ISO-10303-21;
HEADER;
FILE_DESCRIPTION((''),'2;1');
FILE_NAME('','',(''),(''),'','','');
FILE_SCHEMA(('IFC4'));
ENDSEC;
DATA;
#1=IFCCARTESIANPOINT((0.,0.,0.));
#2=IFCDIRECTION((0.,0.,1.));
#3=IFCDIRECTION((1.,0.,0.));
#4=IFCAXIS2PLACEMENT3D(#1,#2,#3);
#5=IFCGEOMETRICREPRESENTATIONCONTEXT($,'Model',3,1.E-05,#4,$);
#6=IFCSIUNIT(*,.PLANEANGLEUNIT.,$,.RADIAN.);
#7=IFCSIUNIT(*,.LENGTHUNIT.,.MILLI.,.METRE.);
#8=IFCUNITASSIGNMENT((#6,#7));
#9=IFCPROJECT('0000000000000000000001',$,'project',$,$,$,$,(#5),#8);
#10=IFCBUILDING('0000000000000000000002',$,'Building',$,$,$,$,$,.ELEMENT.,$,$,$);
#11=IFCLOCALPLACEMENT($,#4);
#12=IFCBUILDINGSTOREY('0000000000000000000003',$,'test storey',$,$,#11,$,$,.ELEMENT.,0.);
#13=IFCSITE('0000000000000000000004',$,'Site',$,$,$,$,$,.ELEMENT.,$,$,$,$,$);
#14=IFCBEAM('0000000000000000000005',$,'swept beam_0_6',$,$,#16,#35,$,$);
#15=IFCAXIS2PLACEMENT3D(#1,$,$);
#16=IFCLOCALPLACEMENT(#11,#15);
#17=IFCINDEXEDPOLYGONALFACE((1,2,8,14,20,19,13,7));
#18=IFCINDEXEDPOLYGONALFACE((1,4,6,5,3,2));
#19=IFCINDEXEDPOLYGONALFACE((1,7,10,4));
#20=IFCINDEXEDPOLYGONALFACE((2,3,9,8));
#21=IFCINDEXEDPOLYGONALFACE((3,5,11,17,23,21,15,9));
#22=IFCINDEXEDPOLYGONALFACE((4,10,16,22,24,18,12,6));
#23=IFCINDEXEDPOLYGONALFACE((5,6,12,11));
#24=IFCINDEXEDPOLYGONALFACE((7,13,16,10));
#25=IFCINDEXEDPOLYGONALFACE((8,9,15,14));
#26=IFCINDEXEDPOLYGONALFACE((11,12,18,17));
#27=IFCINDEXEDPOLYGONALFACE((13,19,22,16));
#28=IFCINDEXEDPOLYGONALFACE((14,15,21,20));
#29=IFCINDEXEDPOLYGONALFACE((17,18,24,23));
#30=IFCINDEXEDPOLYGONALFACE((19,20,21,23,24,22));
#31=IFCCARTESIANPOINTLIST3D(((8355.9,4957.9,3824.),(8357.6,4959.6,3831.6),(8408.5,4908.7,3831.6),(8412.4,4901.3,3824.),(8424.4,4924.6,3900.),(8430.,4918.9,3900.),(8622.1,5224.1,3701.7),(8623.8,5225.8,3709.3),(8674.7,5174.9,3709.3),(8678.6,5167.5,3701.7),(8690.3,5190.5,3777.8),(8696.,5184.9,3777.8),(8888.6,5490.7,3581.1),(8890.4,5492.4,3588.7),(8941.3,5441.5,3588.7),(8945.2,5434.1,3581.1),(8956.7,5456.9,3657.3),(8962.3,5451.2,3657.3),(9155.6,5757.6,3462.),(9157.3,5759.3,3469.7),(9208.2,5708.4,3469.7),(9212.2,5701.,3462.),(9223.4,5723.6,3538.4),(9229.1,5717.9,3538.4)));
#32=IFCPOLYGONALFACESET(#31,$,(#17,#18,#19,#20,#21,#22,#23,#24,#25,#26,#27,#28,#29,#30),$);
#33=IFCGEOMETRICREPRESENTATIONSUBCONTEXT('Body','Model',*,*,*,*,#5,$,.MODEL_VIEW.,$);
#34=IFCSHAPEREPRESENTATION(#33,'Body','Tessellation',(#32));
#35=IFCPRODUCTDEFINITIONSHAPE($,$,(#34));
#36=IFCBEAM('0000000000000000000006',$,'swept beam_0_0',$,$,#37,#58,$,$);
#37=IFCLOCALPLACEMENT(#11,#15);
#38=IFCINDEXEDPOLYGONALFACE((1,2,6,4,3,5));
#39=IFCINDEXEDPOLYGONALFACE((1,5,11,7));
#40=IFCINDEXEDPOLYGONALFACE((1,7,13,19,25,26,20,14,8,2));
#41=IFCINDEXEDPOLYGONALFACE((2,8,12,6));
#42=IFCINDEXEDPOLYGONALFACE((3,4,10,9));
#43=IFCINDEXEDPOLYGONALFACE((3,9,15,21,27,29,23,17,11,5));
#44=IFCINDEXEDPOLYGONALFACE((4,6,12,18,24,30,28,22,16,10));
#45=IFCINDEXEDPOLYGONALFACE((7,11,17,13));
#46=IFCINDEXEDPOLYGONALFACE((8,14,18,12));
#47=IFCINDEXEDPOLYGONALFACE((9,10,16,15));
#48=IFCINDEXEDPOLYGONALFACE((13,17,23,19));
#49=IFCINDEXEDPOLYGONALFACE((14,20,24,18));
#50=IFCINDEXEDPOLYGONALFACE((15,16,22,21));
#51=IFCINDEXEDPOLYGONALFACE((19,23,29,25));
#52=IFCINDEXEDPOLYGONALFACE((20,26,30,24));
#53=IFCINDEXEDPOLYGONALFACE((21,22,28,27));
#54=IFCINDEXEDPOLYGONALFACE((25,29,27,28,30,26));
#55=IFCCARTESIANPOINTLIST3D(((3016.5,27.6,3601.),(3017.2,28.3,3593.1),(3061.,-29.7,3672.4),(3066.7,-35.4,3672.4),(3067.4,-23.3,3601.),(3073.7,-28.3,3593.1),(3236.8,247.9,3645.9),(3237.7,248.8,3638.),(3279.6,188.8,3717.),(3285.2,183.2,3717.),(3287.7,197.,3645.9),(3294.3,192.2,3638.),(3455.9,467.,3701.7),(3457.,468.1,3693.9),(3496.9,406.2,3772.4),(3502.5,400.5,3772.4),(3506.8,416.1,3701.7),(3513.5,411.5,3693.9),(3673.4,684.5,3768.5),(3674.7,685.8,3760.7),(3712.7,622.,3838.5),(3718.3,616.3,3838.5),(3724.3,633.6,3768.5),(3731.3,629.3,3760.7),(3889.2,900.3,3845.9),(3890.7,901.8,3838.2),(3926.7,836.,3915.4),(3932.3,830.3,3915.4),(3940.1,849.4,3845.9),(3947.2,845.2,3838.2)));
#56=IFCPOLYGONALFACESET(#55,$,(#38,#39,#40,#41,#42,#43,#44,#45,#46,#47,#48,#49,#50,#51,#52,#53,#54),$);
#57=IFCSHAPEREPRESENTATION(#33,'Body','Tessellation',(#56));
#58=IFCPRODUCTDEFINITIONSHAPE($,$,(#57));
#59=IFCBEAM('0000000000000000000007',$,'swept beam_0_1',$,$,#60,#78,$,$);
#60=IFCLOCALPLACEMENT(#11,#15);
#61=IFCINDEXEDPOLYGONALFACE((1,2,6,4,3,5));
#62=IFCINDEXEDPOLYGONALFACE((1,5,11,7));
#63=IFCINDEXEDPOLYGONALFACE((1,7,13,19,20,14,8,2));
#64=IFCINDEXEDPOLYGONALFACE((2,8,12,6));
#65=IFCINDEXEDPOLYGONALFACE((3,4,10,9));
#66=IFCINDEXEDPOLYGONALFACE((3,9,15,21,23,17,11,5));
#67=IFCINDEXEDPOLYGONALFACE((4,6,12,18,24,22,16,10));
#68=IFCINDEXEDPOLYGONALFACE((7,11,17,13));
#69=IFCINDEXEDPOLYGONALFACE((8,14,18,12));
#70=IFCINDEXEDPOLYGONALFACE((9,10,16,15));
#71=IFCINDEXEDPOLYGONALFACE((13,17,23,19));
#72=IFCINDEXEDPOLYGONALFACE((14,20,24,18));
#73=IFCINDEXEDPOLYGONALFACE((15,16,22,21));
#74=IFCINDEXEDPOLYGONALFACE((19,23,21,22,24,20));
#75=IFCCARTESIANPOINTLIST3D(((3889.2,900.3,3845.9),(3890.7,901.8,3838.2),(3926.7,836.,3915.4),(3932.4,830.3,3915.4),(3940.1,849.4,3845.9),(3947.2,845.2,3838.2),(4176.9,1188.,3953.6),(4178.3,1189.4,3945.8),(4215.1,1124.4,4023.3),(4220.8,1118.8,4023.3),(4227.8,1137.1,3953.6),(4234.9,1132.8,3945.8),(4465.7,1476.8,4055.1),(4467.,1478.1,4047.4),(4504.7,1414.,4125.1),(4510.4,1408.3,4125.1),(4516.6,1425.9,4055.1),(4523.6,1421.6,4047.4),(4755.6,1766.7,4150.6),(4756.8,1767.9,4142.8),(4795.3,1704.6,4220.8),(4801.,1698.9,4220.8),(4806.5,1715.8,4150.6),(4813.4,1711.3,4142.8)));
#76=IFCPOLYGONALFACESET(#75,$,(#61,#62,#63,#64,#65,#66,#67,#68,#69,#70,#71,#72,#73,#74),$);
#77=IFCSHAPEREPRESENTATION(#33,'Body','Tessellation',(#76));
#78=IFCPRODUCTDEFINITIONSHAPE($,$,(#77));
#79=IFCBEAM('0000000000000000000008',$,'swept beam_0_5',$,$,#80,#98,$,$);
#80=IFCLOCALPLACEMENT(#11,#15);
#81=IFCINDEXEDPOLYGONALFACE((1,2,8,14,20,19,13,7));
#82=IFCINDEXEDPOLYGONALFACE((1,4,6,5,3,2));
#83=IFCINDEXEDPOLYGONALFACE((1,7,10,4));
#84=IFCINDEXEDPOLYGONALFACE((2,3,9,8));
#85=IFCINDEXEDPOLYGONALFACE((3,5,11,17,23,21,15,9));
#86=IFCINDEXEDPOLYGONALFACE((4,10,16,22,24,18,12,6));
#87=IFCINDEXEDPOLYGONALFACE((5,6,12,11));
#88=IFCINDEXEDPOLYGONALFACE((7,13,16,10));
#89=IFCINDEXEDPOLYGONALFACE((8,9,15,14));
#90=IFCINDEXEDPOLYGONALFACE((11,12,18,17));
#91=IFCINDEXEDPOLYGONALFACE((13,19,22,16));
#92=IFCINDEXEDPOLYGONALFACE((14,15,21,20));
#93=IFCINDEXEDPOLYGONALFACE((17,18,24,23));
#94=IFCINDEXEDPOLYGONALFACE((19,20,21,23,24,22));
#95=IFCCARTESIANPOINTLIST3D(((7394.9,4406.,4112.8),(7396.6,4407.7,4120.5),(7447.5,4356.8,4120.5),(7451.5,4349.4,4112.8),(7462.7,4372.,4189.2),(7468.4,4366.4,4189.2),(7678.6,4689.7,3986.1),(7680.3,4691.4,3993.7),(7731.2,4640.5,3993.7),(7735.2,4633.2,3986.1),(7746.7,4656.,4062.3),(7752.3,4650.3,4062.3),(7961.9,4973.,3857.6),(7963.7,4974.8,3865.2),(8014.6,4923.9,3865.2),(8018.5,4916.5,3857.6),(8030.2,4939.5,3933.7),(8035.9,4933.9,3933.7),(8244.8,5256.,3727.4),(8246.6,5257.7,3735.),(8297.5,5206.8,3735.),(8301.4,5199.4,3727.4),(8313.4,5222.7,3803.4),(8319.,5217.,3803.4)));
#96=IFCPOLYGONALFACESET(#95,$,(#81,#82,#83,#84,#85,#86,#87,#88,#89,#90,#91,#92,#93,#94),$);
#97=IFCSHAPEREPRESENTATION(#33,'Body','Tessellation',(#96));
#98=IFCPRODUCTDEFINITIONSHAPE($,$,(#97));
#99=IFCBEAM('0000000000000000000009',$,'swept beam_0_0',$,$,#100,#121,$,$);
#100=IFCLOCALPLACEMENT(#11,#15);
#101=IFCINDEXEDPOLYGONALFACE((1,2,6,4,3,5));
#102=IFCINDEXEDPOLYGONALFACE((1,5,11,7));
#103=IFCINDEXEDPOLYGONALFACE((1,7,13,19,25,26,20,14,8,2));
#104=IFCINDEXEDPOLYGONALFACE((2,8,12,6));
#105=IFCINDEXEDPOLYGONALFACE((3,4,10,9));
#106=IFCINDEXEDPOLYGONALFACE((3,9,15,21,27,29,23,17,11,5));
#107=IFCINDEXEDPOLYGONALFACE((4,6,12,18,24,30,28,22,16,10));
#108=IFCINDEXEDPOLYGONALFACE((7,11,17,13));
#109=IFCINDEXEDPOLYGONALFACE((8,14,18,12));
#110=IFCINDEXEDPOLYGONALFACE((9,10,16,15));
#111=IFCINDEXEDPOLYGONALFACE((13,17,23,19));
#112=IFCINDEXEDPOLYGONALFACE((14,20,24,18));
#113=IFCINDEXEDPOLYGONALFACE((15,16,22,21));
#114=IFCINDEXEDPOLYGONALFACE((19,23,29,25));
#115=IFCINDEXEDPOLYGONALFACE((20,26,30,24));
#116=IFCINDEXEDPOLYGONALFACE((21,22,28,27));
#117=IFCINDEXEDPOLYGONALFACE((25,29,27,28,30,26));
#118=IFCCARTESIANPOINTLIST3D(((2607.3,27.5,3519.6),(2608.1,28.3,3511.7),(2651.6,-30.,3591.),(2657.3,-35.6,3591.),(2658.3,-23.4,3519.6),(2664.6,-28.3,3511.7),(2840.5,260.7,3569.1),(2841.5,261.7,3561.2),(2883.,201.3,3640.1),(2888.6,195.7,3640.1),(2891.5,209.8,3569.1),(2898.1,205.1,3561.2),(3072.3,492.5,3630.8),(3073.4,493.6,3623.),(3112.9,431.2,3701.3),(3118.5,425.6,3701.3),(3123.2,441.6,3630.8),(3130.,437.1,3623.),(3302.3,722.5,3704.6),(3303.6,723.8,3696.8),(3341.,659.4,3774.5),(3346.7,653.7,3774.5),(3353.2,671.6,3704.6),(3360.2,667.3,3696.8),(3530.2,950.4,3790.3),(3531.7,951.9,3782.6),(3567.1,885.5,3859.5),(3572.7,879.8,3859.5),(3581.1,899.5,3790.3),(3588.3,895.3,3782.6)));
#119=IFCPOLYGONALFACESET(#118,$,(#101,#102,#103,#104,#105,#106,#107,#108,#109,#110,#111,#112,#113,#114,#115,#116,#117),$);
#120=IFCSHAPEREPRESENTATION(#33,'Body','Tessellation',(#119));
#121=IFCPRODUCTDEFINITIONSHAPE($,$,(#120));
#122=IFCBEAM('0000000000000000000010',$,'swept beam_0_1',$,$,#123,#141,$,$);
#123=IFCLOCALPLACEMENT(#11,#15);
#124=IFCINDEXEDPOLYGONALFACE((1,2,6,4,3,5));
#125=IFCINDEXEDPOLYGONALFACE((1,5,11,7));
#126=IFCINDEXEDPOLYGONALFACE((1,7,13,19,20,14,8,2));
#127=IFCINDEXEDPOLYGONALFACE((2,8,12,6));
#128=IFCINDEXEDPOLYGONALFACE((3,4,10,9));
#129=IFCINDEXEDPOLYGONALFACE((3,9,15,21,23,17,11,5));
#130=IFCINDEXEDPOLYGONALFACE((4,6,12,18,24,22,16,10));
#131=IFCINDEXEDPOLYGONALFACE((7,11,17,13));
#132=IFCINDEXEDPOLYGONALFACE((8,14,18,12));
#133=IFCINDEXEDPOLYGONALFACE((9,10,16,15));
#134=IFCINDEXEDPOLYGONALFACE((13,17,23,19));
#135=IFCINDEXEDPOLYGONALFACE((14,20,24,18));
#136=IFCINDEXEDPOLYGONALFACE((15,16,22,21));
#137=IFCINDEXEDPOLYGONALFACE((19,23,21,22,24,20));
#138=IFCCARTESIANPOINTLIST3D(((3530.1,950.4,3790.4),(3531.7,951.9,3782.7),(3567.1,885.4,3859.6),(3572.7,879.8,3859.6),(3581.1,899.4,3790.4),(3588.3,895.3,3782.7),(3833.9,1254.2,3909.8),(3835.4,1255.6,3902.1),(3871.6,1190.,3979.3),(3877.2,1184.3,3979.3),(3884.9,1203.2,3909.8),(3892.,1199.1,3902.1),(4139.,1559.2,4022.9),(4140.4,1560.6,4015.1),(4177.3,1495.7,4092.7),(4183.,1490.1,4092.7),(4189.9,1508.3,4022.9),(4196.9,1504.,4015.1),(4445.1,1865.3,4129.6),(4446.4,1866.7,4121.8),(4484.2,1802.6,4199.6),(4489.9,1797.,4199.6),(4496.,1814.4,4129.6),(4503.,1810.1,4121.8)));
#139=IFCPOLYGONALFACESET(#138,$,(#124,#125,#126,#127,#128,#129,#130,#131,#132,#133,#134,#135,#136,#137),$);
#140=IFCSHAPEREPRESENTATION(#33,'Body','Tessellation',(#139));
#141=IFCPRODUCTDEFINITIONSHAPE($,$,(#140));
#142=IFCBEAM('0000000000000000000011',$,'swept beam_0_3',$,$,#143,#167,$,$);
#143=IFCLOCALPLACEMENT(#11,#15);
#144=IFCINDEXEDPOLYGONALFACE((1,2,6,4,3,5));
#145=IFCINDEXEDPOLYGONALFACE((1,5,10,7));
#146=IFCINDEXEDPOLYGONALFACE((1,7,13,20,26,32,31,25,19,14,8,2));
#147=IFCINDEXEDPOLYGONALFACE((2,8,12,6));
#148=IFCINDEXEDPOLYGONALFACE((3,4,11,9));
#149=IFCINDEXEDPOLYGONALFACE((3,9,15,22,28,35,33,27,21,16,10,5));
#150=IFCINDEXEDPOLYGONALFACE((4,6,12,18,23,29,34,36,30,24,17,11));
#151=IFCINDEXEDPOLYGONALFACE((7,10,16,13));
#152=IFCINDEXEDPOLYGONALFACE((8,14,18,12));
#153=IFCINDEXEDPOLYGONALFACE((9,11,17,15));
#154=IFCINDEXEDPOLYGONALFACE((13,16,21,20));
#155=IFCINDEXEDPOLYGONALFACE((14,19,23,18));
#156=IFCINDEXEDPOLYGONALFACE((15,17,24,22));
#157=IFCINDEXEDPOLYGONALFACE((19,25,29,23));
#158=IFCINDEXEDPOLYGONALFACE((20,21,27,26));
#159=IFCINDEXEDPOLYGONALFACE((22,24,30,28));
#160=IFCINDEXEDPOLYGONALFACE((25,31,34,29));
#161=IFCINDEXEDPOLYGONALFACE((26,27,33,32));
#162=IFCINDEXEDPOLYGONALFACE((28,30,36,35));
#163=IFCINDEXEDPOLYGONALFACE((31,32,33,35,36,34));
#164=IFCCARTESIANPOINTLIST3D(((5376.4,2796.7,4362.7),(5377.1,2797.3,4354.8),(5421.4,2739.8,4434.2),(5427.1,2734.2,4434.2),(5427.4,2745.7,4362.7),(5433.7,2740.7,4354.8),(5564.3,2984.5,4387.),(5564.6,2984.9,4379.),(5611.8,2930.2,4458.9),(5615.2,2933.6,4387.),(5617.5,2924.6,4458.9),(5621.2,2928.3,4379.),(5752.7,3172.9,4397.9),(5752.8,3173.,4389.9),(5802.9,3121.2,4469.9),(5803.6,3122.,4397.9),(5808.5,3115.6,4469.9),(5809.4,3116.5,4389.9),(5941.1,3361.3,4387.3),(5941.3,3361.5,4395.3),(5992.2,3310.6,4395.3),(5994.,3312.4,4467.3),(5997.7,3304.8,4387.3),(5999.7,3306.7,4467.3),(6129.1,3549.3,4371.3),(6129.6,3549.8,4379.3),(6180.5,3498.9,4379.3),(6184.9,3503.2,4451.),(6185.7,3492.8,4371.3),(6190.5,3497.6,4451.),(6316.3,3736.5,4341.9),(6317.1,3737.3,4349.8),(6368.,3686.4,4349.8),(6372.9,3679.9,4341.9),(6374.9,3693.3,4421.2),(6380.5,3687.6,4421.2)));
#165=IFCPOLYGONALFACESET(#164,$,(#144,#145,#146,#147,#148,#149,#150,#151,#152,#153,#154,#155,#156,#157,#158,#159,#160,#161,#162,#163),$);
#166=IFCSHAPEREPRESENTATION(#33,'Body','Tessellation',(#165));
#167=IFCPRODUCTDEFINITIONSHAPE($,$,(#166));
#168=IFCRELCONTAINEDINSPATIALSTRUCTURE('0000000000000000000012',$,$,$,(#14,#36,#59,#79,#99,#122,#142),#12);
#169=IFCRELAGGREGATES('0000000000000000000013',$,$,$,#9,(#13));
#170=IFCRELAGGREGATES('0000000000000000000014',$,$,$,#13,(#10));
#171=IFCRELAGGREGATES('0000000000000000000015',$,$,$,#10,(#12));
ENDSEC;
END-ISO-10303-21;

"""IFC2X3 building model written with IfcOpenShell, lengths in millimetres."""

from ifc_helpers import new_model, entity, si_unit, origin_with_axes, place, context, subcontext, project, spatial, element, save


model = new_model("IFC2X3")

# Units and contexts
model_context = context("Model", 3, precision=1e-05, world=origin_with_axes())
body_context = subcontext(model_context, "Body", "Model", "MODEL_VIEW")
ifc_project = project(units=[si_unit("PLANEANGLEUNIT", "RADIAN"), si_unit("LENGTHUNIT", "METRE", prefix="MILLI")], contexts=[model_context])

# Site, building, storey
site = spatial("IfcSite", under=ifc_project, Name="Site", CompositionType="ELEMENT")
building = spatial("IfcBuilding", under=site, Name="Building", CompositionType="ELEMENT")
storey_placement = place(None, origin_with_axes())
storey = spatial("IfcBuildingStorey", under=building, at=storey_placement, Name="test storey", CompositionType="ELEMENT", Elevation=0.0)

# Beams
beam_1_placement = place(storey_placement, origin_with_axes())
element("IfcBeam", 1, at=beam_1_placement, inside=storey, Name="swept beam_0_6", context=body_context, shape_type="SweptSolid", body=[
    entity("IfcRevolvedAreaSolid", entity("IfcArbitraryClosedProfileDef", "AREA", None, entity("IfcPolyline", [entity("IfcCartesianPoint", [-80.0, 40.0]), entity("IfcCartesianPoint", [-80.0, 32.0]), entity("IfcCartesianPoint", [-8.0, 32.0]), entity("IfcCartesianPoint", [-8.0, -40.0]), entity("IfcCartesianPoint", [0.0, -40.0]), entity("IfcCartesianPoint", [0.0, 40.0]), entity("IfcCartesianPoint", [-80.0, 40.0])])), entity("IfcAxis2Placement3D", entity("IfcCartesianPoint", [8384.1, 4929.6, 3824.0]), entity("IfcDirection", [-0.6721, -0.6721, 0.3109]), entity("IfcDirection", [-0.2199, -0.2199, -0.9504])), entity("IfcAxis1Placement", entity("IfcCartesianPoint", [-92548.9, 0.0, 0.0]), entity("IfcDirection", [0.0, 1.0, 0.0])), 0.012831),
])
beam_2_placement = place(storey_placement, origin_with_axes())
element("IfcBeam", 2, at=beam_2_placement, inside=storey, Name="swept beam_0_0", context=body_context, shape_type="SweptSolid", body=[
    entity("IfcRevolvedAreaSolid", entity("IfcArbitraryClosedProfileDef", "AREA", None, entity("IfcPolyline", [entity("IfcCartesianPoint", [-80.0, 40.0]), entity("IfcCartesianPoint", [-80.0, 32.0]), entity("IfcCartesianPoint", [-8.0, 32.0]), entity("IfcCartesianPoint", [-8.0, -40.0]), entity("IfcCartesianPoint", [0.0, -40.0]), entity("IfcCartesianPoint", [0.0, 40.0]), entity("IfcCartesianPoint", [-80.0, 40.0])])), entity("IfcAxis2Placement3D", entity("IfcCartesianPoint", [3045.5, 0.0, 3593.1]), entity("IfcDirection", [-0.7015, -0.7015, -0.1252]), entity("IfcDirection", [0.0885, 0.0885, -0.9921])), entity("IfcAxis1Placement", entity("IfcCartesianPoint", [-8954.0, 0.0, 0.0]), entity("IfcDirection", [0.0, 1.0, 0.0])), 0.140768),
])
beam_3_placement = place(storey_placement, origin_with_axes())
element("IfcBeam", 3, at=beam_3_placement, inside=storey, Name="swept beam_0_1", context=body_context, shape_type="SweptSolid", body=[
    entity("IfcRevolvedAreaSolid", entity("IfcArbitraryClosedProfileDef", "AREA", None, entity("IfcPolyline", [entity("IfcCartesianPoint", [80.0, -40.0]), entity("IfcCartesianPoint", [80.0, -32.0]), entity("IfcCartesianPoint", [8.0, -32.0]), entity("IfcCartesianPoint", [8.0, 40.0]), entity("IfcCartesianPoint", [0.0, 40.0]), entity("IfcCartesianPoint", [0.0, -40.0]), entity("IfcCartesianPoint", [80.0, -40.0])])), entity("IfcAxis2Placement3D", entity("IfcCartesianPoint", [3919.0, 873.5, 3838.2]), entity("IfcDirection", [-0.6822, -0.6822, -0.2631]), entity("IfcDirection", [-0.1861, -0.1861, 0.9648])), entity("IfcAxis1Placement", entity("IfcCartesianPoint", [-28035.2, 0.0, 0.0]), entity("IfcDirection", [0.0, 1.0, 0.0])), 0.045026),
])
beam_4_placement = place(storey_placement, origin_with_axes())
element("IfcBeam", 4, at=beam_4_placement, inside=storey, Name="swept beam_0_5", context=body_context, shape_type="SweptSolid", body=[
    entity("IfcRevolvedAreaSolid", entity("IfcArbitraryClosedProfileDef", "AREA", None, entity("IfcPolyline", [entity("IfcCartesianPoint", [80.0, -40.0]), entity("IfcCartesianPoint", [80.0, -32.0]), entity("IfcCartesianPoint", [8.0, -32.0]), entity("IfcCartesianPoint", [8.0, 40.0]), entity("IfcCartesianPoint", [0.0, 40.0]), entity("IfcCartesianPoint", [0.0, -40.0]), entity("IfcCartesianPoint", [80.0, -40.0])])), entity("IfcAxis2Placement3D", entity("IfcCartesianPoint", [7423.2, 4377.7, 4112.8]), entity("IfcDirection", [-0.6747, -0.6747, 0.2991]), entity("IfcDirection", [0.2115, 0.2115, 0.9542])), entity("IfcAxis1Placement", entity("IfcCartesianPoint", [-96572.0, 0.0, 0.0]), entity("IfcDirection", [0.0, 1.0, 0.0])), 0.013071),
])
beam_5_placement = place(storey_placement, origin_with_axes())
element("IfcBeam", 5, at=beam_5_placement, inside=storey, Name="swept beam_0_0", context=body_context, shape_type="SweptSolid", body=[
    entity("IfcRevolvedAreaSolid", entity("IfcArbitraryClosedProfileDef", "AREA", None, entity("IfcPolyline", [entity("IfcCartesianPoint", [-80.0, 40.0]), entity("IfcCartesianPoint", [-80.0, 32.0]), entity("IfcCartesianPoint", [-8.0, 32.0]), entity("IfcCartesianPoint", [-8.0, -40.0]), entity("IfcCartesianPoint", [0.0, -40.0]), entity("IfcCartesianPoint", [0.0, 40.0]), entity("IfcCartesianPoint", [-80.0, 40.0])])), entity("IfcAxis2Placement3D", entity("IfcCartesianPoint", [2636.4, 0.0, 3511.7]), entity("IfcDirection", [-0.7011, -0.7011, -0.1302]), entity("IfcDirection", [0.0921, 0.0921, -0.9915])), entity("IfcAxis1Placement", entity("IfcCartesianPoint", [-9025.2, 0.0, 0.0]), entity("IfcDirection", [0.0, 1.0, 0.0])), 0.147945),
])
beam_6_placement = place(storey_placement, origin_with_axes())
element("IfcBeam", 6, at=beam_6_placement, inside=storey, Name="swept beam_0_1", context=body_context, shape_type="SweptSolid", body=[
    entity("IfcRevolvedAreaSolid", entity("IfcArbitraryClosedProfileDef", "AREA", None, entity("IfcPolyline", [entity("IfcCartesianPoint", [80.0, -40.0]), entity("IfcCartesianPoint", [80.0, -32.0]), entity("IfcCartesianPoint", [8.0, -32.0]), entity("IfcCartesianPoint", [8.0, 40.0]), entity("IfcCartesianPoint", [0.0, 40.0]), entity("IfcCartesianPoint", [0.0, -40.0]), entity("IfcCartesianPoint", [80.0, -40.0])])), entity("IfcAxis2Placement3D", entity("IfcCartesianPoint", [3560.0, 923.6, 3782.7]), entity("IfcDirection", [-0.6798, -0.6798, -0.275]), entity("IfcDirection", [-0.1944, -0.1944, 0.9615])), entity("IfcAxis1Placement", entity("IfcCartesianPoint", [-30049.4, 0.0, 0.0]), entity("IfcDirection", [0.0, 1.0, 0.0])), 0.044509),
])
beam_7_placement = place(storey_placement, origin_with_axes())
element("IfcBeam", 7, at=beam_7_placement, inside=storey, Name="swept beam_0_3", context=body_context, shape_type="SweptSolid", body=[
    entity("IfcRevolvedAreaSolid", entity("IfcArbitraryClosedProfileDef", "AREA", None, entity("IfcPolyline", [entity("IfcCartesianPoint", [80.0, -40.0]), entity("IfcCartesianPoint", [80.0, -32.0]), entity("IfcCartesianPoint", [8.0, -32.0]), entity("IfcCartesianPoint", [8.0, 40.0]), entity("IfcCartesianPoint", [0.0, 40.0]), entity("IfcCartesianPoint", [0.0, -40.0]), entity("IfcCartesianPoint", [80.0, -40.0])])), entity("IfcAxis2Placement3D", entity("IfcCartesianPoint", [5405.4, 2769.0, 4354.8]), entity("IfcDirection", [-0.7023, -0.7023, -0.1162]), entity("IfcDirection", [-0.0822, -0.0822, 0.9932])), entity("IfcAxis1Placement", entity("IfcCartesianPoint", [-5278.8, 0.0, 0.0]), entity("IfcDirection", [0.0, 1.0, 0.0])), 0.252295),
])

save(model, "model.ifc")
